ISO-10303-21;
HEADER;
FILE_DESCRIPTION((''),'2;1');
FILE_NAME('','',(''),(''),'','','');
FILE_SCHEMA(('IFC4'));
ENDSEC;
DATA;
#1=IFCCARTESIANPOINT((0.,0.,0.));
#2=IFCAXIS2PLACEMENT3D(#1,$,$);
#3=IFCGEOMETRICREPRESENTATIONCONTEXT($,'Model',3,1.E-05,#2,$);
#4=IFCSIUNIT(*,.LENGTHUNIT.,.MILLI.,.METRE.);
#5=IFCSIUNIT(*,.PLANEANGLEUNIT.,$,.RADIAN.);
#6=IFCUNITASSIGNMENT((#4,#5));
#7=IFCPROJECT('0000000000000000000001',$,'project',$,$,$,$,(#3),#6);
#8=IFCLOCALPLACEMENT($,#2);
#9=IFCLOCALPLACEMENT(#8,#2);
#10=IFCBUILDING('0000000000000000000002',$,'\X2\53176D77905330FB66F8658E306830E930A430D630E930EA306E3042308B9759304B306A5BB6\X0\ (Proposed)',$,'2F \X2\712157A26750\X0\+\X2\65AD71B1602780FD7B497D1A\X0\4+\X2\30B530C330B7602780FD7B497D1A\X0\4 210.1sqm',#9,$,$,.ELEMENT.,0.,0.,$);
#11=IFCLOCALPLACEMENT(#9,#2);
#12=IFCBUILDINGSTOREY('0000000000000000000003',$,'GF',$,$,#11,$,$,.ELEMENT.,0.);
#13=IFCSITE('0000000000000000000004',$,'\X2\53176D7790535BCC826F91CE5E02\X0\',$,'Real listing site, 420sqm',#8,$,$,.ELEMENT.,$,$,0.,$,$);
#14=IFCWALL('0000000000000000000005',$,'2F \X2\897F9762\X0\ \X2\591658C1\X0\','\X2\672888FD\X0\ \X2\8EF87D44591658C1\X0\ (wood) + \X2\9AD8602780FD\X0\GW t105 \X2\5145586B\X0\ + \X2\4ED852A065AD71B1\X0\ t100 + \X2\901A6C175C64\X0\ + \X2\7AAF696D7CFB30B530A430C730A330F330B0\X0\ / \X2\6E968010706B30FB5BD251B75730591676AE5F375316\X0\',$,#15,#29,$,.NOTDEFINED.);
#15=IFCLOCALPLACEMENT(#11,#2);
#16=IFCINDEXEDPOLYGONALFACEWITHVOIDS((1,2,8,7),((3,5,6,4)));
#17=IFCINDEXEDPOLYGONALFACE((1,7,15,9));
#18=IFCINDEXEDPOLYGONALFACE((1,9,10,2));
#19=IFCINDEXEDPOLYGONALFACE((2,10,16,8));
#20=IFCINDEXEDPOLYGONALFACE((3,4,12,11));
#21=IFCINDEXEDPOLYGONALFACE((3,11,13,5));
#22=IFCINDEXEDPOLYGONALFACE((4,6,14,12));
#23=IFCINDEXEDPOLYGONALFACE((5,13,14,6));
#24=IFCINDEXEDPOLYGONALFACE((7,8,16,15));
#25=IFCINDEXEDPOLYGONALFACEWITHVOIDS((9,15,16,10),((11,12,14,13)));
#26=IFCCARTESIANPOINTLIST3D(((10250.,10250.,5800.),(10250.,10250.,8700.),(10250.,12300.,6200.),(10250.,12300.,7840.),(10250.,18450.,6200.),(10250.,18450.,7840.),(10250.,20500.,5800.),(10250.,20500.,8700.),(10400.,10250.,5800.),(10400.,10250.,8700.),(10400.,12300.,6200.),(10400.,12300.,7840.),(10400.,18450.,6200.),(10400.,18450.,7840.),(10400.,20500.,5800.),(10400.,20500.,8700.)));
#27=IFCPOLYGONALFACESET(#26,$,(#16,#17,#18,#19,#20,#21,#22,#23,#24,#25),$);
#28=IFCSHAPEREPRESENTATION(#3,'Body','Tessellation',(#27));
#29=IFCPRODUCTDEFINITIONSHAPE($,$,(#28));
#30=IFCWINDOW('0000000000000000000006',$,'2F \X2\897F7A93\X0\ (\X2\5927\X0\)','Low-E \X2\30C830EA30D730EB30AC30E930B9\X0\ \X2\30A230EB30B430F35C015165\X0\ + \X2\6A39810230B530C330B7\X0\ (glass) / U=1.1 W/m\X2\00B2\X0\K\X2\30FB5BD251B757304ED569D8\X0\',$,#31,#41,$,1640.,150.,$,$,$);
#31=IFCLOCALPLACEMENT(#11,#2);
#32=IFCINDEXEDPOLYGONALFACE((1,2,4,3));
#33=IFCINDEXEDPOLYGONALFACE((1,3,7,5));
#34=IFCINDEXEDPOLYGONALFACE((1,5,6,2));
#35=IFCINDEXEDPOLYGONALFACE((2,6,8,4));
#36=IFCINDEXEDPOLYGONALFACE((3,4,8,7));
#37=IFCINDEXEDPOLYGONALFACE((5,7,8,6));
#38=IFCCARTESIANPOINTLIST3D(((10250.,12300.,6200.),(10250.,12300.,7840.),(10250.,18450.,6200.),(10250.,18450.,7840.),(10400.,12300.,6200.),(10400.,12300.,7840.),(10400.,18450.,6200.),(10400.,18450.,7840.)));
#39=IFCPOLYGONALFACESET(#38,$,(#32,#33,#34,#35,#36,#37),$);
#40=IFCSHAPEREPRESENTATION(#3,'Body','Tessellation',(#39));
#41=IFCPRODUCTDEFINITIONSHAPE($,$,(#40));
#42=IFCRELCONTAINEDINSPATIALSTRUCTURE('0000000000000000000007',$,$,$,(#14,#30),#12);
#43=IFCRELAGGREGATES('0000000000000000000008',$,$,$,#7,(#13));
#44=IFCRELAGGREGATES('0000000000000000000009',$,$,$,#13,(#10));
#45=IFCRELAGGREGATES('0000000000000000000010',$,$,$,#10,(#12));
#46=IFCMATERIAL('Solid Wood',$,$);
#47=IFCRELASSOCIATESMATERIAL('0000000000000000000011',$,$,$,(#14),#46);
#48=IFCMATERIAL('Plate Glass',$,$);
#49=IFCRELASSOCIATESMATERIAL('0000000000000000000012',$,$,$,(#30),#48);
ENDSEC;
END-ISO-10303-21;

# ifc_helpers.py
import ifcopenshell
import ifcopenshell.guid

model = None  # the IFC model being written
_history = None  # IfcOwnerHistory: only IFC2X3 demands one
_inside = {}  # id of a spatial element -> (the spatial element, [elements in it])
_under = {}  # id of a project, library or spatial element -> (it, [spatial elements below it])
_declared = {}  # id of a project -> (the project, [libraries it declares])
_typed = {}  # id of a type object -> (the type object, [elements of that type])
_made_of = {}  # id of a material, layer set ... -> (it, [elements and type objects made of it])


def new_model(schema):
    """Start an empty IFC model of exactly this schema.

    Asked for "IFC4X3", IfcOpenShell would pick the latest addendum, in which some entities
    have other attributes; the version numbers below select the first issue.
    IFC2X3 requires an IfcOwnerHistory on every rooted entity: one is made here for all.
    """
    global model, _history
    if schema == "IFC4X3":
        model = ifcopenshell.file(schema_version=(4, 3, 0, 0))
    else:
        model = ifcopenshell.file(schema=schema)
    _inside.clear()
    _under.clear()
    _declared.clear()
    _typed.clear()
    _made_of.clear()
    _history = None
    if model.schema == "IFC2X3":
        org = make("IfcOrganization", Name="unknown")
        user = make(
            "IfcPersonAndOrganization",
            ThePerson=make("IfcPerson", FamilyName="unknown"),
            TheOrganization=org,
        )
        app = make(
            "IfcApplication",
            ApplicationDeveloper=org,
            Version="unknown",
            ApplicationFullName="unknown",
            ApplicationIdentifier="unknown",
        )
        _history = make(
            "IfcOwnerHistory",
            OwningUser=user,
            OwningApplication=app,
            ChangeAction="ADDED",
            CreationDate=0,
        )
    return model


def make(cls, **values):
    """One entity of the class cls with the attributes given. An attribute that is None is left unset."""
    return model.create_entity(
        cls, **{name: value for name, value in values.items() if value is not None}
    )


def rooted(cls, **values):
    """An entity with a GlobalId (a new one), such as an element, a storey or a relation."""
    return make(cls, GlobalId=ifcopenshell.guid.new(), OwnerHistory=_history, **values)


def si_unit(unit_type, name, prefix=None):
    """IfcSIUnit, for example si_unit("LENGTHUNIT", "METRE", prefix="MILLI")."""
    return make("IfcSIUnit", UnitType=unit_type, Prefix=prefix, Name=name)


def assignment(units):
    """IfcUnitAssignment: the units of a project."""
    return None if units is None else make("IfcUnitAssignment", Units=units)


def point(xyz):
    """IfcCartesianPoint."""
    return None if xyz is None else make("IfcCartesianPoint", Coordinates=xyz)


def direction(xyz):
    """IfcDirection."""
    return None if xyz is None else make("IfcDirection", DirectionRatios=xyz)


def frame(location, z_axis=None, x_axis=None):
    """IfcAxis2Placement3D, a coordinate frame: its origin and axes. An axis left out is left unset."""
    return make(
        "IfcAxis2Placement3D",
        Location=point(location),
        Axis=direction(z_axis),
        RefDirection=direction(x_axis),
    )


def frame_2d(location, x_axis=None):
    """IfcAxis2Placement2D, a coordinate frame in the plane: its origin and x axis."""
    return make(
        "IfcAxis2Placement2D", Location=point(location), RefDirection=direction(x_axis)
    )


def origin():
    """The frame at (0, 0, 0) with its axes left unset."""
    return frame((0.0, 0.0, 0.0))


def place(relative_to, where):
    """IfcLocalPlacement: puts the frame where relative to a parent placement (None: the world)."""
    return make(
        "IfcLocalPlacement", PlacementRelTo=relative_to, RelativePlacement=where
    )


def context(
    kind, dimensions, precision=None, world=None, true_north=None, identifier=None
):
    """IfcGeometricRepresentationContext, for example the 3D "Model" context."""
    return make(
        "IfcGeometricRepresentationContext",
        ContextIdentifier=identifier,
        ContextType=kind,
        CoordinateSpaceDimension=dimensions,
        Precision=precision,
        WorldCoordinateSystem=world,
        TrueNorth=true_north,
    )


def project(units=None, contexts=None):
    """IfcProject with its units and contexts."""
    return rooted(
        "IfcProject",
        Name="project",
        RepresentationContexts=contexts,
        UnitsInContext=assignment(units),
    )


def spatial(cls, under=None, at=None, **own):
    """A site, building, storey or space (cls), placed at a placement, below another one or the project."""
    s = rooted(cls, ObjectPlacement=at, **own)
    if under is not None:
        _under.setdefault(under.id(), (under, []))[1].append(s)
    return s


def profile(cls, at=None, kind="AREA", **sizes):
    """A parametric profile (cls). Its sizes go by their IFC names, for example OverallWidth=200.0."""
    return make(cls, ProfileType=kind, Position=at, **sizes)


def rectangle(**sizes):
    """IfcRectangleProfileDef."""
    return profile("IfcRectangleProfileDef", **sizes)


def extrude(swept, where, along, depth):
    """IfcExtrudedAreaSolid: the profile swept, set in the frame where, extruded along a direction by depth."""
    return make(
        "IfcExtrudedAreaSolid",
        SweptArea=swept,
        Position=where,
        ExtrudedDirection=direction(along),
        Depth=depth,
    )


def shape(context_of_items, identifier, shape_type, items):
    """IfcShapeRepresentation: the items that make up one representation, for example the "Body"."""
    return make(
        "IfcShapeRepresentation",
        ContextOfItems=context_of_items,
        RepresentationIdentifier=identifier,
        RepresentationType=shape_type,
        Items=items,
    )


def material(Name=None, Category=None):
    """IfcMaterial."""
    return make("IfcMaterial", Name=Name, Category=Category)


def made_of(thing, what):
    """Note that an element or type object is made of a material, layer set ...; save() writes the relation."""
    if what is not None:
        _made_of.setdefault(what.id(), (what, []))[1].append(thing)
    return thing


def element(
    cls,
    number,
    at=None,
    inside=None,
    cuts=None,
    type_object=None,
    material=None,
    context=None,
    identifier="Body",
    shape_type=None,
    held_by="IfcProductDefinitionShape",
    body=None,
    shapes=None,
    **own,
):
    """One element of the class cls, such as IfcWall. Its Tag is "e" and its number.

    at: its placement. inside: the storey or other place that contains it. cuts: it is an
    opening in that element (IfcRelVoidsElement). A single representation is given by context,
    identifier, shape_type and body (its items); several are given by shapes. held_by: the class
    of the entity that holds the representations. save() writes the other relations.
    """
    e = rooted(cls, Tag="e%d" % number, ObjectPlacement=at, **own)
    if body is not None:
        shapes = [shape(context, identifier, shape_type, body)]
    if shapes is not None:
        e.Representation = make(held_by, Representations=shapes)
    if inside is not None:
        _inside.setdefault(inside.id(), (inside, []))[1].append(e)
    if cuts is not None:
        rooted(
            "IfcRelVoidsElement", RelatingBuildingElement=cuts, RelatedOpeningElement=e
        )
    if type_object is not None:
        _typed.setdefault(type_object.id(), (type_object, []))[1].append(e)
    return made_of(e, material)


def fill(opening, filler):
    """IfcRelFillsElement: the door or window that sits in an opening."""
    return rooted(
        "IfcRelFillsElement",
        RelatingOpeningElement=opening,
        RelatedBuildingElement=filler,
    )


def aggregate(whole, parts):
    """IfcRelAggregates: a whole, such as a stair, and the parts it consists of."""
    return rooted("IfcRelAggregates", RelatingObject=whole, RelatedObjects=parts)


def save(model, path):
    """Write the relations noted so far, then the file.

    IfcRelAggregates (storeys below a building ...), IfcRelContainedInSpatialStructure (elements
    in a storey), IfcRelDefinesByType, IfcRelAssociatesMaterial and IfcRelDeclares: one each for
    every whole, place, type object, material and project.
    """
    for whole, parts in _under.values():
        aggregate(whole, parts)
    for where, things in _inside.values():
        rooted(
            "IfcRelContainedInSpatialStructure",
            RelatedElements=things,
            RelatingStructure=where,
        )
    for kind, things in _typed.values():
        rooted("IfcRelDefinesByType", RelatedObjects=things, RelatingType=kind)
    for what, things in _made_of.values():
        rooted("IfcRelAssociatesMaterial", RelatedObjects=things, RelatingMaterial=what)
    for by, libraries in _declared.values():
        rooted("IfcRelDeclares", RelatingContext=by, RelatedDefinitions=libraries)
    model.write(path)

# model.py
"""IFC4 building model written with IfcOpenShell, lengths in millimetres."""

from ifc_helpers import new_model, si_unit, frame, frame_2d, origin, place, context, project, spatial, rectangle, extrude, material, element, fill, save


model = new_model("IFC4")

# Units and contexts
model_context = context("Model", 3, precision=1e-05, world=origin())
ifc_project = project(units=[si_unit("LENGTHUNIT", "METRE", prefix="MILLI"), si_unit("PLANEANGLEUNIT", "RADIAN")], contexts=[model_context])

# Site, building, storey
site_placement = place(None, origin())
site = spatial("IfcSite", under=ifc_project, at=site_placement, Name="北海道富良野市", ObjectType="Real listing site, 420sqm", CompositionType="ELEMENT", RefElevation=0.0)
building_placement = place(site_placement, origin())
building = spatial("IfcBuilding", under=site, at=building_placement, Name="北海道・書斎とライブラリのある静かな家 (Proposed)", ObjectType="2F 無垢材+断熱性能等級4+サッシ性能等級4 210.1sqm", CompositionType="ELEMENT", ElevationOfRefHeight=0.0, ElevationOfTerrain=0.0)
storey_placement = place(building_placement, origin())
storey = spatial("IfcBuildingStorey", under=building, at=storey_placement, Name="GF", CompositionType="ELEMENT", Elevation=0.0)

# Shared definitions
ifc_material_1 = material(Name="Solid Wood")

# Shared definitions
ifc_material_2 = material(Name="Plate Glass")

# Wall, opening, window
wall_1_placement = place(storey_placement, frame((5125.0, 5125.0, 2900.0)))
wall_1 = element("IfcWall", 1, at=wall_1_placement, inside=storey, material=ifc_material_1, Name="2F 西面 外壁", Description="木製 軸組外壁 (wood) + 高性能GW t105 充填 + 付加断熱 t100 + 通気層 + 窯業系サイディング / 準耐火・寒冷地外皮強化", PredefinedType="NOTDEFINED", context=model_context, shape_type="SweptSolid", body=[
    extrude(rectangle(XDim=150.0, YDim=10250.0, at=frame_2d((75.0, 5125.0))), frame((5125.0, 5125.0, 2900.0)), (0.0, 0.0, 1.0), 2900.0),
])
opening_1_placement = place(storey_placement, frame((5125.0, 6150.0, 3100.0)))
opening_1 = element("IfcOpeningElement", 2, at=opening_1_placement, cuts=wall_1, PredefinedType="NOTDEFINED", context=model_context, shape_type="SweptSolid", body=[
    extrude(rectangle(XDim=150.0, YDim=6150.0, at=frame_2d((75.0, 3075.0))), frame((5125.0, 6150.0, 3100.0)), (0.0, 0.0, 1.0), 1640.0),
])
window_1_placement = place(storey_placement, frame((5125.0, 6150.0, 3100.0)))
window_1 = element("IfcWindow", 3, at=window_1_placement, inside=storey, material=ifc_material_2, Name="2F 西窓 (大)", Description="Low-E トリプルガラス アルゴン封入 + 樹脂サッシ (glass) / U=1.1 W/m²K・寒冷地仕様", OverallHeight=1640.0, OverallWidth=150.0, context=model_context, shape_type="SweptSolid", body=[
    extrude(rectangle(XDim=150.0, YDim=6150.0, at=frame_2d((75.0, 3075.0))), frame((5125.0, 6150.0, 3100.0)), (0.0, 0.0, 1.0), 1640.0),
])
fill(opening_1, window_1)

save(model, "model.ifc")
